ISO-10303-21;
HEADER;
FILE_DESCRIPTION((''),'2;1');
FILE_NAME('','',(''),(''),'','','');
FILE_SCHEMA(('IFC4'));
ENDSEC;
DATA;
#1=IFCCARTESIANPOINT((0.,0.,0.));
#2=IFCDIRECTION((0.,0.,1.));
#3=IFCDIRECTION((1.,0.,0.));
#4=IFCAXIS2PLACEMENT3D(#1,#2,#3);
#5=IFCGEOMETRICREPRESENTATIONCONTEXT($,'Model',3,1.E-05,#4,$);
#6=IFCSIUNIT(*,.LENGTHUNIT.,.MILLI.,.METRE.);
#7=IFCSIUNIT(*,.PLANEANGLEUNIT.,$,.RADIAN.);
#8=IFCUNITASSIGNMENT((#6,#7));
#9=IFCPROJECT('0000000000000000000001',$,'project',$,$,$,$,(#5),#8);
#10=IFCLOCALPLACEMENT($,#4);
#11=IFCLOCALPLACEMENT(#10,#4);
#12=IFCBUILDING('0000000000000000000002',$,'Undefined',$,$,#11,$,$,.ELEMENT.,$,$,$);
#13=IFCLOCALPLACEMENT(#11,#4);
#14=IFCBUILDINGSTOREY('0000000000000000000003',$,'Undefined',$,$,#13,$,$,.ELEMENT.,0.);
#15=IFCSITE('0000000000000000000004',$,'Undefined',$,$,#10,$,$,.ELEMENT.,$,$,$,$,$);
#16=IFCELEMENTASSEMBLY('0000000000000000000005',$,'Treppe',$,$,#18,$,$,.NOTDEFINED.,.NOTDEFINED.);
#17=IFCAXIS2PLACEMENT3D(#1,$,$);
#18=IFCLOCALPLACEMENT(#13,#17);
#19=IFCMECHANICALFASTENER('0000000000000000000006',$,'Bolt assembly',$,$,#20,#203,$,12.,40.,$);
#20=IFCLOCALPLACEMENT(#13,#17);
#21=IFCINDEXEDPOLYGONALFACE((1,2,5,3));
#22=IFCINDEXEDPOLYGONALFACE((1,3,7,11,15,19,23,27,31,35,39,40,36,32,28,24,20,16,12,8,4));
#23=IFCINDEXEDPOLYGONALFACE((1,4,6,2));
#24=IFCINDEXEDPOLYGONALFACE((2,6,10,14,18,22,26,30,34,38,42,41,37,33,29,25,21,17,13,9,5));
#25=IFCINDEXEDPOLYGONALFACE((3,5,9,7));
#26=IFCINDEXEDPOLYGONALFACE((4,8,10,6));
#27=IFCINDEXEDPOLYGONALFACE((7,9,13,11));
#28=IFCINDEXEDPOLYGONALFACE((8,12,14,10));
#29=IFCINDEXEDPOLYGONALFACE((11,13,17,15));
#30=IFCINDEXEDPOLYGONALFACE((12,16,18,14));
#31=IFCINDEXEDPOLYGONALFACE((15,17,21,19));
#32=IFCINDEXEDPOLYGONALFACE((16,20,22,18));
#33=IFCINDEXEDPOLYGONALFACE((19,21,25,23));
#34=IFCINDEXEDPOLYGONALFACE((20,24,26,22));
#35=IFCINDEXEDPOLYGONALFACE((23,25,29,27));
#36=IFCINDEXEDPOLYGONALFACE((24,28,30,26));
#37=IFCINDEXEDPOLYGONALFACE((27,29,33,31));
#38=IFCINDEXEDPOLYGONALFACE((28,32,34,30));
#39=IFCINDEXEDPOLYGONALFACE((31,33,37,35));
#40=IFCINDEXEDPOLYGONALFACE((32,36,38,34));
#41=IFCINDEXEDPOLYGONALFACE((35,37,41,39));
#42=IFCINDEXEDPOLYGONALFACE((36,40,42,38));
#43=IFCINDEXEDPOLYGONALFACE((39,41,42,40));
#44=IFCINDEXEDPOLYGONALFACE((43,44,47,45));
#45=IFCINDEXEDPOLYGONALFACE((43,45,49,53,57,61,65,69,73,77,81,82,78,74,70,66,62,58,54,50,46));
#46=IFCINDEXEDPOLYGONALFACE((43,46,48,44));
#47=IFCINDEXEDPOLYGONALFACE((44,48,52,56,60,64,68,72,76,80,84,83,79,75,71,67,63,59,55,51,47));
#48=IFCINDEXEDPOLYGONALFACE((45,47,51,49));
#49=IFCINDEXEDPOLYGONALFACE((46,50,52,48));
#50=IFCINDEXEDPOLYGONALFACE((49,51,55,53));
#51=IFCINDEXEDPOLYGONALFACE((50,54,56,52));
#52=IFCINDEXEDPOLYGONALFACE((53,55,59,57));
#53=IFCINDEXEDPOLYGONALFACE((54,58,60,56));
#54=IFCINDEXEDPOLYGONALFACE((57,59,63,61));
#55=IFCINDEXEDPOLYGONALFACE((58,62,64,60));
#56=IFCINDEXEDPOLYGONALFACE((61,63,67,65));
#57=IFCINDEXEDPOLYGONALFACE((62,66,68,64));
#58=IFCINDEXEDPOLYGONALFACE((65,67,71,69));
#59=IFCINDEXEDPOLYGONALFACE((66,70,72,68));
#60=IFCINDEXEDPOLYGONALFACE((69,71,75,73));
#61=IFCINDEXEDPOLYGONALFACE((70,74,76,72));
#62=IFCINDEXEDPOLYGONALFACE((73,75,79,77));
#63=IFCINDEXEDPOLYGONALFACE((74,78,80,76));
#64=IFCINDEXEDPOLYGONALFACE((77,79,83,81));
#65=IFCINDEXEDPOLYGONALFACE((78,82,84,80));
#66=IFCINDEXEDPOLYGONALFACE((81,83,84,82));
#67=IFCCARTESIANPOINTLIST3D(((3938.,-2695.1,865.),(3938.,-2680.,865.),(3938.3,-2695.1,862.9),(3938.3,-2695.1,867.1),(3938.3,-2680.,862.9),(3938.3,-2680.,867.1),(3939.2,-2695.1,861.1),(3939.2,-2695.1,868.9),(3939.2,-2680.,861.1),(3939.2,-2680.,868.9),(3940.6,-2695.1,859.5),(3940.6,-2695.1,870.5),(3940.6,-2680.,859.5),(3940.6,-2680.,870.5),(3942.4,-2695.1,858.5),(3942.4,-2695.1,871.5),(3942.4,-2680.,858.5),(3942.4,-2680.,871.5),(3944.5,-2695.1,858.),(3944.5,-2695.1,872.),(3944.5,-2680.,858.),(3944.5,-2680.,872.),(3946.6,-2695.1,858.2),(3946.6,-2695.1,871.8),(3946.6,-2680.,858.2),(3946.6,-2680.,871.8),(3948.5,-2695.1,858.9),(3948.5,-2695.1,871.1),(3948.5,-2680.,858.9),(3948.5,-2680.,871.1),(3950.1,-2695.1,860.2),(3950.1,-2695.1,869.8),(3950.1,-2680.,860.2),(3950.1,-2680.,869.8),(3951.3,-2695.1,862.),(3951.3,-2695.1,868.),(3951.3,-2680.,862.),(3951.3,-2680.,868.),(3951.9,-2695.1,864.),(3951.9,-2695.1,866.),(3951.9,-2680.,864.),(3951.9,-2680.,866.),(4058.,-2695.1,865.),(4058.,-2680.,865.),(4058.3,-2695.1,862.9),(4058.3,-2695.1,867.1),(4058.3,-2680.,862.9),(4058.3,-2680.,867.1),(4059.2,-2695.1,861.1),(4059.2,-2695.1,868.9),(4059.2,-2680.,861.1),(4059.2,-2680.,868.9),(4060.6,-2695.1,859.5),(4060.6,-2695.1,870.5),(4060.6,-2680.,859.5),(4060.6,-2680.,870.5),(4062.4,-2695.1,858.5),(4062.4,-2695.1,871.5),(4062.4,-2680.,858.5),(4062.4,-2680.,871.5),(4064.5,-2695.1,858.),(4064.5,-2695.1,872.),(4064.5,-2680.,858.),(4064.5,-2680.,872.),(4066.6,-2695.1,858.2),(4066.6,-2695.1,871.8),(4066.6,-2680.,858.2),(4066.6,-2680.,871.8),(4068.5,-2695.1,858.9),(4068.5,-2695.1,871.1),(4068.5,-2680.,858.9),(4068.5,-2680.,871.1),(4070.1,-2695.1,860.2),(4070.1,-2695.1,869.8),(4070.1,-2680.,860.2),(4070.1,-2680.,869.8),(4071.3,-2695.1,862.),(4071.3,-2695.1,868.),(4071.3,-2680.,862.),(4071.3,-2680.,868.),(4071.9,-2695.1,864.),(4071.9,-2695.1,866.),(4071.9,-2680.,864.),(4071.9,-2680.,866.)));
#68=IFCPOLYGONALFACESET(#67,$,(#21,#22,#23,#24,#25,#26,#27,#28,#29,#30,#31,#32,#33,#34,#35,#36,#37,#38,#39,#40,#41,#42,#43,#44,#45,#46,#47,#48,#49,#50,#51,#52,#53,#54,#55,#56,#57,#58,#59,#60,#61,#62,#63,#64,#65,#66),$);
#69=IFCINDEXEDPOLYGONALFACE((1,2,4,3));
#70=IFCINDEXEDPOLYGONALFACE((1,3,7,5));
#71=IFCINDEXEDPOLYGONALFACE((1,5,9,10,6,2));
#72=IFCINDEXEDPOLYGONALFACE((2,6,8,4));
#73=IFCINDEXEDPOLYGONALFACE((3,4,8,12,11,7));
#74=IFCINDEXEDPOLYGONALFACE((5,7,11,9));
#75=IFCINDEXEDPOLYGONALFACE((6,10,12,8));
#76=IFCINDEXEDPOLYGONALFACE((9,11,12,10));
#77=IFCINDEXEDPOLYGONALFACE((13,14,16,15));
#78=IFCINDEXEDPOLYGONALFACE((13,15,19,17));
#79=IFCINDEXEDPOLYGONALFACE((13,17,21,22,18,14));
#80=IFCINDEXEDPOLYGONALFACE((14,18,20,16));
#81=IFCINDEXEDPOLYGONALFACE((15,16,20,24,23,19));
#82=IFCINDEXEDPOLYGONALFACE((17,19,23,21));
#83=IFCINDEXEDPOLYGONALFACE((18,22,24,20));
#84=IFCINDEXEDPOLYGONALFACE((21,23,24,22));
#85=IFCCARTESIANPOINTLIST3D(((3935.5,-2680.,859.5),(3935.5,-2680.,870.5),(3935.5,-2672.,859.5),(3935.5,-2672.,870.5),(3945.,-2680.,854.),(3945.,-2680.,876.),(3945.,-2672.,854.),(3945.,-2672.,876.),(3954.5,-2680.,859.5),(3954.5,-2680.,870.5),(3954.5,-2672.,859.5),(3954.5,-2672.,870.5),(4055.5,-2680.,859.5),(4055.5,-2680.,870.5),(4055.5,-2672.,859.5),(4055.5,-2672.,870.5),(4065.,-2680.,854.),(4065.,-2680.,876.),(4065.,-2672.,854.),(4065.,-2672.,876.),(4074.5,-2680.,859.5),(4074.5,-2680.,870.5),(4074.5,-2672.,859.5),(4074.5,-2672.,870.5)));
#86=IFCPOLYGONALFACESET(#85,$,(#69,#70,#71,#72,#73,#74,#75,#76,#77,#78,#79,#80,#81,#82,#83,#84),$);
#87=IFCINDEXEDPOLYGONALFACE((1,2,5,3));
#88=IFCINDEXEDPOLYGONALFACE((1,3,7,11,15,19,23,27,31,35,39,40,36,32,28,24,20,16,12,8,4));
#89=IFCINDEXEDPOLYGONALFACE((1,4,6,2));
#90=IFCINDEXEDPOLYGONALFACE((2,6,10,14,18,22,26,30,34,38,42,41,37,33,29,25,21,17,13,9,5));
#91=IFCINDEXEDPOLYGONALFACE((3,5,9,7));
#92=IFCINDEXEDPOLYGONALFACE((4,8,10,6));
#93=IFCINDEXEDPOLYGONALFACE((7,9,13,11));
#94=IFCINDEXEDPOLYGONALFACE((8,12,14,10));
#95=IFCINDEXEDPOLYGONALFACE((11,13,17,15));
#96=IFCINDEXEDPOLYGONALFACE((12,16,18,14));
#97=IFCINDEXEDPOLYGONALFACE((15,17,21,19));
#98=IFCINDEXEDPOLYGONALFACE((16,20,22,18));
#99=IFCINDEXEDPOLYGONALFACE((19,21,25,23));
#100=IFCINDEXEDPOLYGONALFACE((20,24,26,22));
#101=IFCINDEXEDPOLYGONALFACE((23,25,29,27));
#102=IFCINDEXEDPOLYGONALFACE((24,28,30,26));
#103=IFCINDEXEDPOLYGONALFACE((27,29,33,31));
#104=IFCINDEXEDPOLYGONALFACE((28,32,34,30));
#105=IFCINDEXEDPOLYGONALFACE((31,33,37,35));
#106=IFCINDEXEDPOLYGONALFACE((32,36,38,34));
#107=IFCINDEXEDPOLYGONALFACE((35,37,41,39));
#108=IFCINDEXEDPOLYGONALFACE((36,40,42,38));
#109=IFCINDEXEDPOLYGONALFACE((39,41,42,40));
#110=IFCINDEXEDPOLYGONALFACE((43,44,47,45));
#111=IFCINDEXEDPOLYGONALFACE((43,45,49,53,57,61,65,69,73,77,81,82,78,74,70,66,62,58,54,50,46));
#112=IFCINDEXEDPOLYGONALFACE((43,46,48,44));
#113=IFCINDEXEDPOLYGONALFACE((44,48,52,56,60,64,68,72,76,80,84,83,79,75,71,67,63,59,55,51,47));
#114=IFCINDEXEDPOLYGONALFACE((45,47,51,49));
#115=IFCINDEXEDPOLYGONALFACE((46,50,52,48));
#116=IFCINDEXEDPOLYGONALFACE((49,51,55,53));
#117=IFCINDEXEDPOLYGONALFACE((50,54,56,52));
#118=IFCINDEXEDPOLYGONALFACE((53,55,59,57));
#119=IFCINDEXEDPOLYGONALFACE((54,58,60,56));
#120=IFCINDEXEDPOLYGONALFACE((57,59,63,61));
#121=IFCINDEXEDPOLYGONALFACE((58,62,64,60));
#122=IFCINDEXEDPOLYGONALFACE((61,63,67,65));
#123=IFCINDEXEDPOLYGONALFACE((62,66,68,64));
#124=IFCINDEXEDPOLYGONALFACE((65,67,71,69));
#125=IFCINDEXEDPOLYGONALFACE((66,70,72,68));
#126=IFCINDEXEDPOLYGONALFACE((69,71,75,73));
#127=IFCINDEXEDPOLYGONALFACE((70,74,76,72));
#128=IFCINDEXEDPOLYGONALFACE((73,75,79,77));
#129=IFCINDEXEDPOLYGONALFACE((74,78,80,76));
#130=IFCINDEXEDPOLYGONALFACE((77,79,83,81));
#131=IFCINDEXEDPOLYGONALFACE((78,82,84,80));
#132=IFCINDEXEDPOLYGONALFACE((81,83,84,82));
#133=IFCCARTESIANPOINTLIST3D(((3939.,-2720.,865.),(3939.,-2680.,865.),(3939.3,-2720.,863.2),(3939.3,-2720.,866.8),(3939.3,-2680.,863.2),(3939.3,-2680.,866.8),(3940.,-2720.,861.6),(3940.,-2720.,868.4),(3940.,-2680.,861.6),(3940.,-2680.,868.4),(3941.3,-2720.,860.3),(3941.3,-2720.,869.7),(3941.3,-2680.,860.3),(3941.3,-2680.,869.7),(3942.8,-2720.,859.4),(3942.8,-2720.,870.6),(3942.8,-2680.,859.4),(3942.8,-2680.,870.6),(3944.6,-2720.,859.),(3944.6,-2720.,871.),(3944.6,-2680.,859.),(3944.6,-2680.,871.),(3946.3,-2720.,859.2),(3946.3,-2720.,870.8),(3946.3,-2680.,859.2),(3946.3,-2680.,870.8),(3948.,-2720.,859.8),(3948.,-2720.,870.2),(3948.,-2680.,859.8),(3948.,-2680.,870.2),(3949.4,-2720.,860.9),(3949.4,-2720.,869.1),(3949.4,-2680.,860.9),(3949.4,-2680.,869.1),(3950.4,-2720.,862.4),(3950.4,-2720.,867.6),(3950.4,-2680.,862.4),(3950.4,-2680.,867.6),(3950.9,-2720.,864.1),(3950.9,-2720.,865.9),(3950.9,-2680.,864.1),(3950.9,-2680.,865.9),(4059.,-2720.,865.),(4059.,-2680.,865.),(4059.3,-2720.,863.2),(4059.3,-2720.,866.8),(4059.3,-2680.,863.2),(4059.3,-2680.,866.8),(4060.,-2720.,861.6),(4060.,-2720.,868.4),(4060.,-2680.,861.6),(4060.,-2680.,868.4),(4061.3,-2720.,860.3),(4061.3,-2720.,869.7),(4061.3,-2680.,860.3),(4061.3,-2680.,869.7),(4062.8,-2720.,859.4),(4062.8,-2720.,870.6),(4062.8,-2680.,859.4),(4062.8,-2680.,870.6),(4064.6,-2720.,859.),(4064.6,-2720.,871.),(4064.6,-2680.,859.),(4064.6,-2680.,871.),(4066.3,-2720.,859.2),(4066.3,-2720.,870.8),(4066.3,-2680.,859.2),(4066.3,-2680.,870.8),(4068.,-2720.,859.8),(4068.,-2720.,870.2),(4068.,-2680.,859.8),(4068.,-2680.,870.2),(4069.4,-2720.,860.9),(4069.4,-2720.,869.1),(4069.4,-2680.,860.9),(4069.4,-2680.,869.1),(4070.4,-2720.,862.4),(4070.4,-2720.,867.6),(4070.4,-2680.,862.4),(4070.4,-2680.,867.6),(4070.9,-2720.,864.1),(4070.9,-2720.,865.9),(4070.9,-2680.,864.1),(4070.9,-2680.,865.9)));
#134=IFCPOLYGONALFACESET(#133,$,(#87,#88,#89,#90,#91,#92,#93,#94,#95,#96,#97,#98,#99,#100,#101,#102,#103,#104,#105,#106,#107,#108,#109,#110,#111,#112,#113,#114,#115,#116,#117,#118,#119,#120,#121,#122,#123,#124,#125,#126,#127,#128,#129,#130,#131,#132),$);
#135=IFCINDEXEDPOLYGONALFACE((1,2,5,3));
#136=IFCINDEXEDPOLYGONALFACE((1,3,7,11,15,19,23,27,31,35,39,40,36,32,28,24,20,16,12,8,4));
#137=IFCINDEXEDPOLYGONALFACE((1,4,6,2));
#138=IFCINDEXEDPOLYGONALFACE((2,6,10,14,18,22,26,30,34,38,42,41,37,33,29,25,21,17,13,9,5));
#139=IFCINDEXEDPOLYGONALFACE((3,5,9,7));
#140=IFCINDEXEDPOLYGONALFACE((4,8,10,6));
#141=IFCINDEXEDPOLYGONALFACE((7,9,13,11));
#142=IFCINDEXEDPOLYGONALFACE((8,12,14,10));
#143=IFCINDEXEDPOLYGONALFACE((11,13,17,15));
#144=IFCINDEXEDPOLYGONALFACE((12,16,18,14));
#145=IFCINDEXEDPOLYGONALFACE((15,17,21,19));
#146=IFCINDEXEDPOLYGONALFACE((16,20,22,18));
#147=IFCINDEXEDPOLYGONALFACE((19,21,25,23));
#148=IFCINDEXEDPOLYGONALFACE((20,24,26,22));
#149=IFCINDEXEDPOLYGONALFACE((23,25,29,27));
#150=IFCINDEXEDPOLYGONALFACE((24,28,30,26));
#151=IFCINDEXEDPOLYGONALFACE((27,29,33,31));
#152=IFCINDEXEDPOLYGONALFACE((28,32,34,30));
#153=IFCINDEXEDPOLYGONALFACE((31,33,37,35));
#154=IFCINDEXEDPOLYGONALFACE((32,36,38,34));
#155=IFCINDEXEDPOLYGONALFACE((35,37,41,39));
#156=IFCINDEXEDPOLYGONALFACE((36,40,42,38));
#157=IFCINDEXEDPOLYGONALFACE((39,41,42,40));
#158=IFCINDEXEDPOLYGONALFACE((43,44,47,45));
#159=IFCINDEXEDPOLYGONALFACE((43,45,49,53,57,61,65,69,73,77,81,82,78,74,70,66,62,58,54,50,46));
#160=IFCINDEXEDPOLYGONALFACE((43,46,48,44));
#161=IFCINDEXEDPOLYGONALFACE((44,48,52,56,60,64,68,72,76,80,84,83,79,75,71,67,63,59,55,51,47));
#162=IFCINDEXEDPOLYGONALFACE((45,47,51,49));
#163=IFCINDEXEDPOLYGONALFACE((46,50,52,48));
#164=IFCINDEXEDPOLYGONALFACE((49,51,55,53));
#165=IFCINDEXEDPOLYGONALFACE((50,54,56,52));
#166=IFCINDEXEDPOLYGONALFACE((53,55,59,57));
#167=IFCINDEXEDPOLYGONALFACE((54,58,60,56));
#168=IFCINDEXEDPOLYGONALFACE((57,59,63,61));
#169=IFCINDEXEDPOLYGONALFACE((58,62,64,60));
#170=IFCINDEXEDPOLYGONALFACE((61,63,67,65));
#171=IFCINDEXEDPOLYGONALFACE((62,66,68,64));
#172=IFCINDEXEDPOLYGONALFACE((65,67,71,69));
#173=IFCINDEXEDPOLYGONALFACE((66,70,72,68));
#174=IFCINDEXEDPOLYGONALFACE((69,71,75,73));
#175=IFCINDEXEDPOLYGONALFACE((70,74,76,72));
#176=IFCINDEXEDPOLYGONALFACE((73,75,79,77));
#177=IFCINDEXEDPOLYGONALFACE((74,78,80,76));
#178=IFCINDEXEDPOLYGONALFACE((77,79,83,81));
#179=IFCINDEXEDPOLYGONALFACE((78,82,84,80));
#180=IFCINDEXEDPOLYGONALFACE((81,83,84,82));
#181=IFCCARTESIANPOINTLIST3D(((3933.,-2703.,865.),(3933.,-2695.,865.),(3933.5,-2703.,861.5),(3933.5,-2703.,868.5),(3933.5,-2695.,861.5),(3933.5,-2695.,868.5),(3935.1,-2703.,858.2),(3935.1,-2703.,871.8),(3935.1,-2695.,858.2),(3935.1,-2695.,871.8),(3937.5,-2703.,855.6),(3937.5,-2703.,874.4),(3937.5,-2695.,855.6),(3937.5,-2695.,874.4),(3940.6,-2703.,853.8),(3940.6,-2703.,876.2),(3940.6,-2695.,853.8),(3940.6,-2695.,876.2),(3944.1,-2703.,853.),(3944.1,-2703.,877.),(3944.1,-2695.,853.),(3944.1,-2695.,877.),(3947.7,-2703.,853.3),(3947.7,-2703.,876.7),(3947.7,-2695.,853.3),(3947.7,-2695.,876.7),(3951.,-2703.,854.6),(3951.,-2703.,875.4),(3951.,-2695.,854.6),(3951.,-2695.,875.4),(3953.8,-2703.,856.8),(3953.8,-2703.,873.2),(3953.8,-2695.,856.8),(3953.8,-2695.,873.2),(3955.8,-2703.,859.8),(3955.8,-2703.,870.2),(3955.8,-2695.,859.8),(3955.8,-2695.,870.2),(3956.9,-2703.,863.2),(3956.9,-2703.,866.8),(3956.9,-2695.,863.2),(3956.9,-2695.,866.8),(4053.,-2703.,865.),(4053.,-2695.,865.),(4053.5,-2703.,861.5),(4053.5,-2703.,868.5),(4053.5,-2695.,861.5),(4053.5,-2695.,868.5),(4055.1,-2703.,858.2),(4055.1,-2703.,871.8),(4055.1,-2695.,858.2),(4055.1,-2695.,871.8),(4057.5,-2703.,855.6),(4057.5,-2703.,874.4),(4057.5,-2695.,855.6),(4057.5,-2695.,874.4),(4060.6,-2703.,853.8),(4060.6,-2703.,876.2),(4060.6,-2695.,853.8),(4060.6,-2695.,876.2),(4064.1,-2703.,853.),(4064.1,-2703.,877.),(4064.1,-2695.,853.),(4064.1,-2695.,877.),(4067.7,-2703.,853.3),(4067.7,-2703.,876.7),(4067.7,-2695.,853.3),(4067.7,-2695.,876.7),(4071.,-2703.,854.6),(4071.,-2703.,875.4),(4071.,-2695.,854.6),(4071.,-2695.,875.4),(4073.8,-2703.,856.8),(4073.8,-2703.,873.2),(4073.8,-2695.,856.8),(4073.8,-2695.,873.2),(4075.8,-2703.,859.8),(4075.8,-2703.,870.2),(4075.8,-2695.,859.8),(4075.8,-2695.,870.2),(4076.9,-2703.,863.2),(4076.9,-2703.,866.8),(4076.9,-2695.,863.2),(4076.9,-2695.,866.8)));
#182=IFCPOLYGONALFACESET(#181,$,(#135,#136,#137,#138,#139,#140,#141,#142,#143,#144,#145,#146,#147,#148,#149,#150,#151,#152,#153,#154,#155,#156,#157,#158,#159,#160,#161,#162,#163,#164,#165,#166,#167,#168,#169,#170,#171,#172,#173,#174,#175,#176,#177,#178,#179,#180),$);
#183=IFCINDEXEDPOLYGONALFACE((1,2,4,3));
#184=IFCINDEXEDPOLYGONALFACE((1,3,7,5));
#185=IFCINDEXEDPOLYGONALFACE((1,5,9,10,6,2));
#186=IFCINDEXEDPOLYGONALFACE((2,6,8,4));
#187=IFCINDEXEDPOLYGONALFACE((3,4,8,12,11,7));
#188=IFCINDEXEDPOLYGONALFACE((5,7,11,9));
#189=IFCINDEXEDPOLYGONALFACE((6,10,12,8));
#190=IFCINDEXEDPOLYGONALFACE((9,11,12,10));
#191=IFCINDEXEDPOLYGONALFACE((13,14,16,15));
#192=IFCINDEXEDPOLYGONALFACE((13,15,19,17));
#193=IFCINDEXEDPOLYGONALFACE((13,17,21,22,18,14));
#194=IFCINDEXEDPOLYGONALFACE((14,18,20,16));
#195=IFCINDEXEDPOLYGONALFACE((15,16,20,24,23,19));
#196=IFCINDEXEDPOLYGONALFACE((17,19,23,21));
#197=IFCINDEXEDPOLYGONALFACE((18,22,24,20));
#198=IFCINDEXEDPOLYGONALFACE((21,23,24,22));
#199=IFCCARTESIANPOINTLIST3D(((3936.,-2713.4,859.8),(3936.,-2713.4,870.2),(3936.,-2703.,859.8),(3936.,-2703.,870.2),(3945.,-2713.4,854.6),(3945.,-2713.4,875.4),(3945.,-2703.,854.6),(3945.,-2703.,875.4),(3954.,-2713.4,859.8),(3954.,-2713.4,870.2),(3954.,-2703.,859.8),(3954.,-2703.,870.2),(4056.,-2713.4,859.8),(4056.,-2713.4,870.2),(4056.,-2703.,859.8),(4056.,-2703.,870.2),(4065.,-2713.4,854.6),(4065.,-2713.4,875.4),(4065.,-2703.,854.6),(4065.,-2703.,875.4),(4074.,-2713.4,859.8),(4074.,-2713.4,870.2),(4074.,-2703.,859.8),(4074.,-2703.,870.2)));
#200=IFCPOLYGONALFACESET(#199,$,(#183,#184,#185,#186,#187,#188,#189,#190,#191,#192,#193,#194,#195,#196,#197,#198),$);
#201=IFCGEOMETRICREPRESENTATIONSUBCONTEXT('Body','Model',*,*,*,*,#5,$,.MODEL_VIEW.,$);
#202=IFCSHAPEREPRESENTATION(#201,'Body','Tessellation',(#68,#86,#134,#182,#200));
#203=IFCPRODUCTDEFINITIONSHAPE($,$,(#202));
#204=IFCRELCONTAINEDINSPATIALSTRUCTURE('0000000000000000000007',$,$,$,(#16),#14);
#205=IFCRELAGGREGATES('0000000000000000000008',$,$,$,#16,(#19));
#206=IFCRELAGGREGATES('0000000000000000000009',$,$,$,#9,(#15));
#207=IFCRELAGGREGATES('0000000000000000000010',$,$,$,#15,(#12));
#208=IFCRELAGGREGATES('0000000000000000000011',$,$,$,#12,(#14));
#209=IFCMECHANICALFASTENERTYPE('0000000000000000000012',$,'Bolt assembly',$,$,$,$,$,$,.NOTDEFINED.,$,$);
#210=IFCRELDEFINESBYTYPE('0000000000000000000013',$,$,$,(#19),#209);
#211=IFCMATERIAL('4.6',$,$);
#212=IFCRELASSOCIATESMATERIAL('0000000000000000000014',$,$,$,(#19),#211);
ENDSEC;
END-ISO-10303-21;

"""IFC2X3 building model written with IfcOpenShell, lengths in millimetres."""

from ifc_helpers import new_model, si_unit, frame, origin_with_axes, origin_2d_with_axis, place, context, subcontext, project, spatial, polyline, circle, outline, extrude, source, transform, mapped, material, type_object, element, aggregate, save


model = new_model("IFC2X3")

# Units and contexts
model_context = context("Model", 3, precision=1e-05, world=origin_with_axes())
body_context = subcontext(model_context, "Body", "Model", "MODEL_VIEW")
ifc_project = project(units=[si_unit("LENGTHUNIT", "METRE", prefix="MILLI"), si_unit("PLANEANGLEUNIT", "RADIAN")], contexts=[model_context])

# Site, building, storey
site_placement = place(None, origin_with_axes())
site = spatial("IfcSite", under=ifc_project, at=site_placement, Name="Undefined", CompositionType="ELEMENT")
building_placement = place(site_placement, origin_with_axes())
building = spatial("IfcBuilding", under=site, at=building_placement, Name="Undefined", CompositionType="ELEMENT")
storey_placement = place(building_placement, origin_with_axes())
storey = spatial("IfcBuildingStorey", under=building, at=storey_placement, Name="Undefined", CompositionType="ELEMENT", Elevation=0.0)

# Element assembly, mechanical fastener
ifc_material_1 = material(Name="4.6")
mechanical_fastener_type = type_object("IfcMechanicalFastenerType", Name="Bolt assembly")
assembly_1_placement = place(storey_placement, origin_with_axes())
assembly_1 = element("IfcElementAssembly", 1, at=assembly_1_placement, inside=storey, Name="Treppe", AssemblyPlace="NOTDEFINED", PredefinedType="NOTDEFINED")
shared_shape_1 = source(origin_with_axes(), body_context, "Body", "SweptSolid", [
    extrude(circle(Radius=7.0, at=origin_2d_with_axis()), frame((0.0, -15.0, 0.0), z_axis=(0.0, 1.0, 0.0), x_axis=(1.0, 0.0, 0.0)), (0.0, 0.0, 1.0), 15.1),
    extrude(outline(polyline([(9.5, -5.5), (9.5, 5.5), (0.0, 11.0), (-9.5, 5.5), (-9.5, -5.5), (0.0, -11.0), (9.5, -5.5)])), frame((0.0, -23.0, 0.0), z_axis=(0.0, 1.0, 0.0), x_axis=(1.0, 0.0, 0.0)), (0.0, 0.0, 1.0), 8.0),
    extrude(circle(Radius=6.0, at=origin_2d_with_axis()), frame((0.0, -15.0, 0.0), z_axis=(0.0, 1.0, 0.0), x_axis=(1.0, 0.0, 0.0)), (0.0, 0.0, 1.0), 40.0),
    extrude(circle(Radius=12.0, at=origin_2d_with_axis()), frame((0.0, 0.0, 0.0), z_axis=(0.0, 1.0, 0.0), x_axis=(1.0, 0.0, 0.0)), (0.0, 0.0, 1.0), 8.0),
    extrude(outline(polyline([(9.0, -5.2), (9.0, 5.2), (0.0, 10.4), (-9.0, 5.2), (-9.0, -5.2), (0.0, -10.4), (9.0, -5.2)])), frame((0.0, 8.0, 0.0), z_axis=(0.0, 1.0, 0.0), x_axis=(1.0, 0.0, 0.0)), (0.0, 0.0, 1.0), 10.4),
])
mechanical_fastener_1_placement = place(assembly_1_placement, frame((4065.0, -2695.0, 865.0), z_axis=(0.0, 0.0, 1.0), x_axis=(-1.0, 0.0, 0.0)))
mechanical_fastener_1 = element("IfcMechanicalFastener", 2, at=mechanical_fastener_1_placement, type_object=mechanical_fastener_type, material=ifc_material_1, Name="Bolt assembly", NominalDiameter=12.0, NominalLength=40.0, context=body_context, shape_type="MappedRepresentation", body=[
    mapped(shared_shape_1, transform((0.0, 0.0, 0.0))),
    mapped(shared_shape_1, transform((120.0, 0.0, 0.0))),
])
aggregate(assembly_1, [mechanical_fastener_1])

save(model, "model.ifc")
